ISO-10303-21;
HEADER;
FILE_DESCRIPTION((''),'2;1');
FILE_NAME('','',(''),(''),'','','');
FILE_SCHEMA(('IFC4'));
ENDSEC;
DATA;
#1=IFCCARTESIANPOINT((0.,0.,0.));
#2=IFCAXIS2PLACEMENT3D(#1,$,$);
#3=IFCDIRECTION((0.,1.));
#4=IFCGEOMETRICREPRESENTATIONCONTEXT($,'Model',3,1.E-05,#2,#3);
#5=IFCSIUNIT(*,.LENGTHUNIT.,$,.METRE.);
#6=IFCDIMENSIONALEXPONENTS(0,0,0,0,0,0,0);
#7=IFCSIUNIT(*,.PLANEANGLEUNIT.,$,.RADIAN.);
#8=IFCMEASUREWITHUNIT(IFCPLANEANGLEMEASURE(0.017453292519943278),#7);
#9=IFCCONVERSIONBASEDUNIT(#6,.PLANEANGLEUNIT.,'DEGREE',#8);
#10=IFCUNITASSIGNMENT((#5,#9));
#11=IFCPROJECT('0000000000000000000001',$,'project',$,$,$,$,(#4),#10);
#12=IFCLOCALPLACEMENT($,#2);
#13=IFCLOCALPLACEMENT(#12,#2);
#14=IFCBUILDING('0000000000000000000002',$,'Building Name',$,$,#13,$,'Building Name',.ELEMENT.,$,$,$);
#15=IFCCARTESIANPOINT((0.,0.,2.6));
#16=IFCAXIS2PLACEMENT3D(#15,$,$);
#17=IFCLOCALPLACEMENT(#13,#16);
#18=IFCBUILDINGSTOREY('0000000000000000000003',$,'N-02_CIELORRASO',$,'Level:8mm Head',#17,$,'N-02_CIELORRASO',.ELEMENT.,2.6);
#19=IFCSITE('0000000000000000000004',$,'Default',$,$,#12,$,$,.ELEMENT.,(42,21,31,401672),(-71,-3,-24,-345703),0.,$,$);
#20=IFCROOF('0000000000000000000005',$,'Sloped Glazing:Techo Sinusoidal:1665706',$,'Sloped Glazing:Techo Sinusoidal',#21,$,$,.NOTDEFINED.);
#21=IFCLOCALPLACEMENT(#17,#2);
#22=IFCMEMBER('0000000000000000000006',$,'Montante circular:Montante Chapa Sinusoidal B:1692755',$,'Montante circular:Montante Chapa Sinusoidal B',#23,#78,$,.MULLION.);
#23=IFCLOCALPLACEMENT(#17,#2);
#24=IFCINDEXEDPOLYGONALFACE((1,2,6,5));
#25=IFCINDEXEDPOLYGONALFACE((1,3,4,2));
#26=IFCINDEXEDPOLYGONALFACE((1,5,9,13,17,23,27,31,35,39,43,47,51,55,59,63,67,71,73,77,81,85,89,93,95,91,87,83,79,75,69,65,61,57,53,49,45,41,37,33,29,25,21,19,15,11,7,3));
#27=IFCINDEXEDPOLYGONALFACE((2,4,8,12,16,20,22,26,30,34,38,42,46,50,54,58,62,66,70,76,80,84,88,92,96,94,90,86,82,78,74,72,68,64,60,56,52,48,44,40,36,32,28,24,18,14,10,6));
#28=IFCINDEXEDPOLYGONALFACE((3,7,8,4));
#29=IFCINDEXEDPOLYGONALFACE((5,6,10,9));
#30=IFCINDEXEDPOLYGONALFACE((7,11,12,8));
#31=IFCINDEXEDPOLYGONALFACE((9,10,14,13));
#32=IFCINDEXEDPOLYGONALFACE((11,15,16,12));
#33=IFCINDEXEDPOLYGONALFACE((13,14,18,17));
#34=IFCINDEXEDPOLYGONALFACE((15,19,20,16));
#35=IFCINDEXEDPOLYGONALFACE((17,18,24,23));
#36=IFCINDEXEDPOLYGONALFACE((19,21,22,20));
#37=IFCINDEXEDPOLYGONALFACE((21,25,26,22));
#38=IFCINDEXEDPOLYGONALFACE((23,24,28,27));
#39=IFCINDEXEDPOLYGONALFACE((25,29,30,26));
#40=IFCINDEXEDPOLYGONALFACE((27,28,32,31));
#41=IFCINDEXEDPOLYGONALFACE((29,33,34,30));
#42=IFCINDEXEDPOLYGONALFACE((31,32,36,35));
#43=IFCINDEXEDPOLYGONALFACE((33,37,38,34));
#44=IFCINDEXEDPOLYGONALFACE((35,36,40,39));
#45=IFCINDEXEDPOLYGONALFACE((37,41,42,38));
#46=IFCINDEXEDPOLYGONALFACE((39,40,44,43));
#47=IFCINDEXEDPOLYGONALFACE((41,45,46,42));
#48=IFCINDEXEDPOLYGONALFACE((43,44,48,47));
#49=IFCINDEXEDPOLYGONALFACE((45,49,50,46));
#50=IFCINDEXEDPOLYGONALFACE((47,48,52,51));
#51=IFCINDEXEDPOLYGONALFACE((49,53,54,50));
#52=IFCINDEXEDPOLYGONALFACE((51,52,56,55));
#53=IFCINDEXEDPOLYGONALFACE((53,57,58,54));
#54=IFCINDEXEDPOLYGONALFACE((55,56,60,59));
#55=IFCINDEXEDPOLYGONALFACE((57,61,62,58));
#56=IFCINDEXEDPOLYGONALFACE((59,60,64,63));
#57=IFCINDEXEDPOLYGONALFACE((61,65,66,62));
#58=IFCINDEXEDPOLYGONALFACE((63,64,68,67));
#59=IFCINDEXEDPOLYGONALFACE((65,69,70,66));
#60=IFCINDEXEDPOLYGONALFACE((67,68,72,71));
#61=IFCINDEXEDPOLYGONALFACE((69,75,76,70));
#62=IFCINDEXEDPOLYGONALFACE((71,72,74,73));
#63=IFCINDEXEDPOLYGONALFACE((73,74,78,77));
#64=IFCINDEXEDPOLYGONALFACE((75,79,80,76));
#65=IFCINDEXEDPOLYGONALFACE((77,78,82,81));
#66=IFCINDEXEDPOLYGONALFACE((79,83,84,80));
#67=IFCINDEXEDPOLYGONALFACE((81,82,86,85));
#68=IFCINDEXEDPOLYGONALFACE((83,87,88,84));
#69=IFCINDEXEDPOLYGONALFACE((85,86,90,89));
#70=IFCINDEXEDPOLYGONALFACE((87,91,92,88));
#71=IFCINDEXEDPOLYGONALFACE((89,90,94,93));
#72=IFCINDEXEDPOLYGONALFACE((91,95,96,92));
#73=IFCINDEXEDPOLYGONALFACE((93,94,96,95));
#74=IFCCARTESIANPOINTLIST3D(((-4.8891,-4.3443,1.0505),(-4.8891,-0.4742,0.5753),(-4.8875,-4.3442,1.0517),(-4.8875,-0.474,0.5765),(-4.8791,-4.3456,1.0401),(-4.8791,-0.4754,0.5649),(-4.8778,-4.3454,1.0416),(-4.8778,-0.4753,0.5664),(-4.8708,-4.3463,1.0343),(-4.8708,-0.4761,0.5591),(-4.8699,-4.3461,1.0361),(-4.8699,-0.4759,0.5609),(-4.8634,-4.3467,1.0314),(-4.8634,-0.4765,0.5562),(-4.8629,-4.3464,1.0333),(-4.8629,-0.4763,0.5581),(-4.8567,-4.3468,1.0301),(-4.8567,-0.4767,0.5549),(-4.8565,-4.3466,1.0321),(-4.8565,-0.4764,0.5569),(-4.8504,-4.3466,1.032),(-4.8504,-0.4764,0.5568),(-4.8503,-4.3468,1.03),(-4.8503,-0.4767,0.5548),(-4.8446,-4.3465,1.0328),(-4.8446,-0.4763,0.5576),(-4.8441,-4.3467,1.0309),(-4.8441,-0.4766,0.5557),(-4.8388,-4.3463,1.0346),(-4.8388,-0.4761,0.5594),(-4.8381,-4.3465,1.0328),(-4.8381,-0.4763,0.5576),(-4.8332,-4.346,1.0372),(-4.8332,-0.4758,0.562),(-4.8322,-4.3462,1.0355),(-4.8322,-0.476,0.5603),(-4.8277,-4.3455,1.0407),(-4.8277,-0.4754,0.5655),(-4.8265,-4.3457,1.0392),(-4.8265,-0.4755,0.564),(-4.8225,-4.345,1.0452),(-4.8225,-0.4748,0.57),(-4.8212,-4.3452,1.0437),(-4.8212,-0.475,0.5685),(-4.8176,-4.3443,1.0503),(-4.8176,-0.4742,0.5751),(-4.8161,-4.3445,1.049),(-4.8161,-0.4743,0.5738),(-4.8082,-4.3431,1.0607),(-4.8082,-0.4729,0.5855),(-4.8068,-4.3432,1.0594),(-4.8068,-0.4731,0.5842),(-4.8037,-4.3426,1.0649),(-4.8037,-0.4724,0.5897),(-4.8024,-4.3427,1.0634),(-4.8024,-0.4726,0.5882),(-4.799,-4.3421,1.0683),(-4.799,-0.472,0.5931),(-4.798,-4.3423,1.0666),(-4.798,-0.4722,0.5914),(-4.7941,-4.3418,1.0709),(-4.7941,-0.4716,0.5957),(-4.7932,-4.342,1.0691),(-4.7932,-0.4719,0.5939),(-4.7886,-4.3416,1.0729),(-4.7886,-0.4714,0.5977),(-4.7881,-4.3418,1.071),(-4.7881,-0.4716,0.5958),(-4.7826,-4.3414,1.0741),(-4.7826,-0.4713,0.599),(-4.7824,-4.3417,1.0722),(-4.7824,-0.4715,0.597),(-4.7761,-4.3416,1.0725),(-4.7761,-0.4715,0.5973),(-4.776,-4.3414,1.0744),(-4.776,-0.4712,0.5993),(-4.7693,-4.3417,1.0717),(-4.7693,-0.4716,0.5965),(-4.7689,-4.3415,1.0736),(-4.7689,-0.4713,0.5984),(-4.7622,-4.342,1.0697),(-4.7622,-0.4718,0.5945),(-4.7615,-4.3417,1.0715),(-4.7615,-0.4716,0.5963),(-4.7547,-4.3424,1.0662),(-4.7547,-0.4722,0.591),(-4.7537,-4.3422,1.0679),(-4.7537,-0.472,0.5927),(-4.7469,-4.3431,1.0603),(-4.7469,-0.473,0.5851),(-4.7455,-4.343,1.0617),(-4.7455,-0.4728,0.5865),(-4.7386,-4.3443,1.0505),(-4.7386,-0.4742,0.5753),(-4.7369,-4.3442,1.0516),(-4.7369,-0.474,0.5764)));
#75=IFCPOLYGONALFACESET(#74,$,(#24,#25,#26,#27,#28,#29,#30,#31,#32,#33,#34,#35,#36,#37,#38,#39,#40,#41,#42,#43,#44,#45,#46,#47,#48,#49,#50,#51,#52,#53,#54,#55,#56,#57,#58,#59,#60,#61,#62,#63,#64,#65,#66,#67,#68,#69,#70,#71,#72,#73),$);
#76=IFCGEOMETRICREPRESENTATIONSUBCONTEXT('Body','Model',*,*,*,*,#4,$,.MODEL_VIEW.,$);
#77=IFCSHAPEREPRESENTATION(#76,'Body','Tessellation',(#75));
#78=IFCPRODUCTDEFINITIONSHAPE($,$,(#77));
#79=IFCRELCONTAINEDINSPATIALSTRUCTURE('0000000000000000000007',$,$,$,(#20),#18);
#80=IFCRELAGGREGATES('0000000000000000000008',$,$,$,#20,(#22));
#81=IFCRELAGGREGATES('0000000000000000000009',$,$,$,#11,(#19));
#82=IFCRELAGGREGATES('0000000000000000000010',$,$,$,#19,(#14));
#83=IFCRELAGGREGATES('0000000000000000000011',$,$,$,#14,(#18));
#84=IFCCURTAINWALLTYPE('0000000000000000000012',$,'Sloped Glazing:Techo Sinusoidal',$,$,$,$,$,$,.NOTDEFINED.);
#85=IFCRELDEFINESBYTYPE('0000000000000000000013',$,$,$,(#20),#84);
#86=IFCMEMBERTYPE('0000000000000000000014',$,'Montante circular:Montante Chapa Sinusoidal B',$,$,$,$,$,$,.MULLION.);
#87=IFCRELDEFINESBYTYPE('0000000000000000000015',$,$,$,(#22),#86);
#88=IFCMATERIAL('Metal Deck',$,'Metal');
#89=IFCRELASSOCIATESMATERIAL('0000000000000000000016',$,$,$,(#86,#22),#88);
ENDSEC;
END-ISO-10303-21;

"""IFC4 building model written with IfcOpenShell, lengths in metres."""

from ifc_helpers import new_model, entity, si_unit, converted_unit, direction, frame, origin, place, context, subcontext, project, spatial, indexed_curve, outline, extrude, source, transform, mapped, material, type_object, type_shapes, element, aggregate, save


model = new_model("IFC4")

# Units and contexts
model_context = context("Model", 3, precision=1e-05, world=origin(), true_north=direction((0.0, 1.0)))
body_context = subcontext(model_context, "Body", "Model", "MODEL_VIEW")
ifc_project = project(units=[si_unit("LENGTHUNIT", "METRE"), converted_unit("PLANEANGLEUNIT", "DEGREE", entity("IfcPlaneAngleMeasure", 0.017453292519943278), si_unit("PLANEANGLEUNIT", "RADIAN"), dimensions=[0, 0, 0, 0, 0, 0, 0])], contexts=[model_context])

# Site, building, storey
site_placement = place(None, origin())
site = spatial("IfcSite", under=ifc_project, at=site_placement, Name="Default", CompositionType="ELEMENT", RefLatitude=(42, 21, 31, 401672), RefLongitude=(-71, -3, -24, -345703), RefElevation=0.0)
building_placement = place(site_placement, origin())
building = spatial("IfcBuilding", under=site, at=building_placement, Name="Building Name", LongName="Building Name", CompositionType="ELEMENT")
storey_placement = place(building_placement, frame((0.0, 0.0, 2.6)))
storey = spatial("IfcBuildingStorey", under=building, at=storey_placement, Name="N-02_CIELORRASO", ObjectType="Level:8mm Head", LongName="N-02_CIELORRASO", CompositionType="ELEMENT", Elevation=2.6)

# Roof, member
curtain_wall_type = type_object("IfcCurtainWallType", Name="Sloped Glazing:Techo Sinusoidal", PredefinedType="NOTDEFINED")
ifc_material = material(Name="Metal Deck", Category="Metal")
roof_1_placement = place(storey_placement, frame((0.0, 0.0, -2.6)))
roof_1 = element("IfcRoof", 1, at=roof_1_placement, inside=storey, type_object=curtain_wall_type, Name="Sloped Glazing:Techo Sinusoidal:1665706", ObjectType="Sloped Glazing:Techo Sinusoidal", PredefinedType="NOTDEFINED")
member_type_1 = type_object("IfcMemberType", Name="Montante circular:Montante Chapa Sinusoidal B", PredefinedType="MULLION", material=ifc_material)
shared_shape_1 = source(origin(), body_context, "Body", "SweptSolid", [
    extrude(outline(indexed_curve([(0.0595, -0.0443), (0.0615, -0.0443), (0.0603, -0.031), (0.0572, -0.0213), (0.053, -0.0138), (0.0481, -0.0078), (0.0427, -0.003), (0.0372, 0.0005), (0.0315, 0.0029), (0.0259, 0.0044), (0.0203, 0.0051), (0.0146, 0.005), (0.0084, 0.0041), (-0.0053, 0.0009), (-0.0123, -0.0005), (-0.0191, -0.0012), (-0.0256, -0.001), (-0.0317, 0.0001), (-0.0375, 0.0019), (-0.0428, 0.0046), (-0.0477, 0.0081), (-0.0522, 0.0128), (-0.0563, 0.0191), (-0.0597, 0.0282), (-0.0617, 0.0421), (-0.0637, 0.042), (-0.0616, 0.0277), (-0.0581, 0.0182), (-0.0537, 0.0116), (-0.049, 0.0066), (-0.0438, 0.0028), (-0.0382, 0.0001), (-0.0322, -0.0019), (-0.0258, -0.003), (-0.019, -0.0032), (-0.012, -0.0025), (-0.0048, -0.0011), (0.0088, 0.0021), (0.0147, 0.003), (0.0202, 0.0031), (0.0255, 0.0024), (0.0309, 0.001), (0.0362, -0.0013), (0.0415, -0.0046), (0.0466, -0.0092), (0.0513, -0.0149), (0.0554, -0.0221), (0.0584, -0.0314), (0.0595, -0.0443)], self_intersect=False)), frame((-0.007, 0.0228, -3.8992), z_axis=(0.0, 0.0, 1.0), x_axis=(-0.819152, -0.573576, 0.0)), (0.0, 0.0, 1.0), 3.8992),
])
type_shapes(member_type_1, [shared_shape_1])
member_1_placement = place(roof_1_placement, frame((-4.8198, -4.3413, 3.6752), z_axis=(0.0, -0.992546, 0.121869), x_axis=(-1.0, 0.0, 0.0)))
member_1 = element("IfcMember", 2, at=member_1_placement, type_object=member_type_1, material=ifc_material, Name="Montante circular:Montante Chapa Sinusoidal B:1692755", ObjectType="Montante circular:Montante Chapa Sinusoidal B", PredefinedType="MULLION", context=body_context, shape_type="MappedRepresentation", body=[
    mapped(shared_shape_1, transform((0.0, 0.0, 0.0), scale=1.0)),
])
aggregate(roof_1, [member_1])

save(model, "model.ifc")
